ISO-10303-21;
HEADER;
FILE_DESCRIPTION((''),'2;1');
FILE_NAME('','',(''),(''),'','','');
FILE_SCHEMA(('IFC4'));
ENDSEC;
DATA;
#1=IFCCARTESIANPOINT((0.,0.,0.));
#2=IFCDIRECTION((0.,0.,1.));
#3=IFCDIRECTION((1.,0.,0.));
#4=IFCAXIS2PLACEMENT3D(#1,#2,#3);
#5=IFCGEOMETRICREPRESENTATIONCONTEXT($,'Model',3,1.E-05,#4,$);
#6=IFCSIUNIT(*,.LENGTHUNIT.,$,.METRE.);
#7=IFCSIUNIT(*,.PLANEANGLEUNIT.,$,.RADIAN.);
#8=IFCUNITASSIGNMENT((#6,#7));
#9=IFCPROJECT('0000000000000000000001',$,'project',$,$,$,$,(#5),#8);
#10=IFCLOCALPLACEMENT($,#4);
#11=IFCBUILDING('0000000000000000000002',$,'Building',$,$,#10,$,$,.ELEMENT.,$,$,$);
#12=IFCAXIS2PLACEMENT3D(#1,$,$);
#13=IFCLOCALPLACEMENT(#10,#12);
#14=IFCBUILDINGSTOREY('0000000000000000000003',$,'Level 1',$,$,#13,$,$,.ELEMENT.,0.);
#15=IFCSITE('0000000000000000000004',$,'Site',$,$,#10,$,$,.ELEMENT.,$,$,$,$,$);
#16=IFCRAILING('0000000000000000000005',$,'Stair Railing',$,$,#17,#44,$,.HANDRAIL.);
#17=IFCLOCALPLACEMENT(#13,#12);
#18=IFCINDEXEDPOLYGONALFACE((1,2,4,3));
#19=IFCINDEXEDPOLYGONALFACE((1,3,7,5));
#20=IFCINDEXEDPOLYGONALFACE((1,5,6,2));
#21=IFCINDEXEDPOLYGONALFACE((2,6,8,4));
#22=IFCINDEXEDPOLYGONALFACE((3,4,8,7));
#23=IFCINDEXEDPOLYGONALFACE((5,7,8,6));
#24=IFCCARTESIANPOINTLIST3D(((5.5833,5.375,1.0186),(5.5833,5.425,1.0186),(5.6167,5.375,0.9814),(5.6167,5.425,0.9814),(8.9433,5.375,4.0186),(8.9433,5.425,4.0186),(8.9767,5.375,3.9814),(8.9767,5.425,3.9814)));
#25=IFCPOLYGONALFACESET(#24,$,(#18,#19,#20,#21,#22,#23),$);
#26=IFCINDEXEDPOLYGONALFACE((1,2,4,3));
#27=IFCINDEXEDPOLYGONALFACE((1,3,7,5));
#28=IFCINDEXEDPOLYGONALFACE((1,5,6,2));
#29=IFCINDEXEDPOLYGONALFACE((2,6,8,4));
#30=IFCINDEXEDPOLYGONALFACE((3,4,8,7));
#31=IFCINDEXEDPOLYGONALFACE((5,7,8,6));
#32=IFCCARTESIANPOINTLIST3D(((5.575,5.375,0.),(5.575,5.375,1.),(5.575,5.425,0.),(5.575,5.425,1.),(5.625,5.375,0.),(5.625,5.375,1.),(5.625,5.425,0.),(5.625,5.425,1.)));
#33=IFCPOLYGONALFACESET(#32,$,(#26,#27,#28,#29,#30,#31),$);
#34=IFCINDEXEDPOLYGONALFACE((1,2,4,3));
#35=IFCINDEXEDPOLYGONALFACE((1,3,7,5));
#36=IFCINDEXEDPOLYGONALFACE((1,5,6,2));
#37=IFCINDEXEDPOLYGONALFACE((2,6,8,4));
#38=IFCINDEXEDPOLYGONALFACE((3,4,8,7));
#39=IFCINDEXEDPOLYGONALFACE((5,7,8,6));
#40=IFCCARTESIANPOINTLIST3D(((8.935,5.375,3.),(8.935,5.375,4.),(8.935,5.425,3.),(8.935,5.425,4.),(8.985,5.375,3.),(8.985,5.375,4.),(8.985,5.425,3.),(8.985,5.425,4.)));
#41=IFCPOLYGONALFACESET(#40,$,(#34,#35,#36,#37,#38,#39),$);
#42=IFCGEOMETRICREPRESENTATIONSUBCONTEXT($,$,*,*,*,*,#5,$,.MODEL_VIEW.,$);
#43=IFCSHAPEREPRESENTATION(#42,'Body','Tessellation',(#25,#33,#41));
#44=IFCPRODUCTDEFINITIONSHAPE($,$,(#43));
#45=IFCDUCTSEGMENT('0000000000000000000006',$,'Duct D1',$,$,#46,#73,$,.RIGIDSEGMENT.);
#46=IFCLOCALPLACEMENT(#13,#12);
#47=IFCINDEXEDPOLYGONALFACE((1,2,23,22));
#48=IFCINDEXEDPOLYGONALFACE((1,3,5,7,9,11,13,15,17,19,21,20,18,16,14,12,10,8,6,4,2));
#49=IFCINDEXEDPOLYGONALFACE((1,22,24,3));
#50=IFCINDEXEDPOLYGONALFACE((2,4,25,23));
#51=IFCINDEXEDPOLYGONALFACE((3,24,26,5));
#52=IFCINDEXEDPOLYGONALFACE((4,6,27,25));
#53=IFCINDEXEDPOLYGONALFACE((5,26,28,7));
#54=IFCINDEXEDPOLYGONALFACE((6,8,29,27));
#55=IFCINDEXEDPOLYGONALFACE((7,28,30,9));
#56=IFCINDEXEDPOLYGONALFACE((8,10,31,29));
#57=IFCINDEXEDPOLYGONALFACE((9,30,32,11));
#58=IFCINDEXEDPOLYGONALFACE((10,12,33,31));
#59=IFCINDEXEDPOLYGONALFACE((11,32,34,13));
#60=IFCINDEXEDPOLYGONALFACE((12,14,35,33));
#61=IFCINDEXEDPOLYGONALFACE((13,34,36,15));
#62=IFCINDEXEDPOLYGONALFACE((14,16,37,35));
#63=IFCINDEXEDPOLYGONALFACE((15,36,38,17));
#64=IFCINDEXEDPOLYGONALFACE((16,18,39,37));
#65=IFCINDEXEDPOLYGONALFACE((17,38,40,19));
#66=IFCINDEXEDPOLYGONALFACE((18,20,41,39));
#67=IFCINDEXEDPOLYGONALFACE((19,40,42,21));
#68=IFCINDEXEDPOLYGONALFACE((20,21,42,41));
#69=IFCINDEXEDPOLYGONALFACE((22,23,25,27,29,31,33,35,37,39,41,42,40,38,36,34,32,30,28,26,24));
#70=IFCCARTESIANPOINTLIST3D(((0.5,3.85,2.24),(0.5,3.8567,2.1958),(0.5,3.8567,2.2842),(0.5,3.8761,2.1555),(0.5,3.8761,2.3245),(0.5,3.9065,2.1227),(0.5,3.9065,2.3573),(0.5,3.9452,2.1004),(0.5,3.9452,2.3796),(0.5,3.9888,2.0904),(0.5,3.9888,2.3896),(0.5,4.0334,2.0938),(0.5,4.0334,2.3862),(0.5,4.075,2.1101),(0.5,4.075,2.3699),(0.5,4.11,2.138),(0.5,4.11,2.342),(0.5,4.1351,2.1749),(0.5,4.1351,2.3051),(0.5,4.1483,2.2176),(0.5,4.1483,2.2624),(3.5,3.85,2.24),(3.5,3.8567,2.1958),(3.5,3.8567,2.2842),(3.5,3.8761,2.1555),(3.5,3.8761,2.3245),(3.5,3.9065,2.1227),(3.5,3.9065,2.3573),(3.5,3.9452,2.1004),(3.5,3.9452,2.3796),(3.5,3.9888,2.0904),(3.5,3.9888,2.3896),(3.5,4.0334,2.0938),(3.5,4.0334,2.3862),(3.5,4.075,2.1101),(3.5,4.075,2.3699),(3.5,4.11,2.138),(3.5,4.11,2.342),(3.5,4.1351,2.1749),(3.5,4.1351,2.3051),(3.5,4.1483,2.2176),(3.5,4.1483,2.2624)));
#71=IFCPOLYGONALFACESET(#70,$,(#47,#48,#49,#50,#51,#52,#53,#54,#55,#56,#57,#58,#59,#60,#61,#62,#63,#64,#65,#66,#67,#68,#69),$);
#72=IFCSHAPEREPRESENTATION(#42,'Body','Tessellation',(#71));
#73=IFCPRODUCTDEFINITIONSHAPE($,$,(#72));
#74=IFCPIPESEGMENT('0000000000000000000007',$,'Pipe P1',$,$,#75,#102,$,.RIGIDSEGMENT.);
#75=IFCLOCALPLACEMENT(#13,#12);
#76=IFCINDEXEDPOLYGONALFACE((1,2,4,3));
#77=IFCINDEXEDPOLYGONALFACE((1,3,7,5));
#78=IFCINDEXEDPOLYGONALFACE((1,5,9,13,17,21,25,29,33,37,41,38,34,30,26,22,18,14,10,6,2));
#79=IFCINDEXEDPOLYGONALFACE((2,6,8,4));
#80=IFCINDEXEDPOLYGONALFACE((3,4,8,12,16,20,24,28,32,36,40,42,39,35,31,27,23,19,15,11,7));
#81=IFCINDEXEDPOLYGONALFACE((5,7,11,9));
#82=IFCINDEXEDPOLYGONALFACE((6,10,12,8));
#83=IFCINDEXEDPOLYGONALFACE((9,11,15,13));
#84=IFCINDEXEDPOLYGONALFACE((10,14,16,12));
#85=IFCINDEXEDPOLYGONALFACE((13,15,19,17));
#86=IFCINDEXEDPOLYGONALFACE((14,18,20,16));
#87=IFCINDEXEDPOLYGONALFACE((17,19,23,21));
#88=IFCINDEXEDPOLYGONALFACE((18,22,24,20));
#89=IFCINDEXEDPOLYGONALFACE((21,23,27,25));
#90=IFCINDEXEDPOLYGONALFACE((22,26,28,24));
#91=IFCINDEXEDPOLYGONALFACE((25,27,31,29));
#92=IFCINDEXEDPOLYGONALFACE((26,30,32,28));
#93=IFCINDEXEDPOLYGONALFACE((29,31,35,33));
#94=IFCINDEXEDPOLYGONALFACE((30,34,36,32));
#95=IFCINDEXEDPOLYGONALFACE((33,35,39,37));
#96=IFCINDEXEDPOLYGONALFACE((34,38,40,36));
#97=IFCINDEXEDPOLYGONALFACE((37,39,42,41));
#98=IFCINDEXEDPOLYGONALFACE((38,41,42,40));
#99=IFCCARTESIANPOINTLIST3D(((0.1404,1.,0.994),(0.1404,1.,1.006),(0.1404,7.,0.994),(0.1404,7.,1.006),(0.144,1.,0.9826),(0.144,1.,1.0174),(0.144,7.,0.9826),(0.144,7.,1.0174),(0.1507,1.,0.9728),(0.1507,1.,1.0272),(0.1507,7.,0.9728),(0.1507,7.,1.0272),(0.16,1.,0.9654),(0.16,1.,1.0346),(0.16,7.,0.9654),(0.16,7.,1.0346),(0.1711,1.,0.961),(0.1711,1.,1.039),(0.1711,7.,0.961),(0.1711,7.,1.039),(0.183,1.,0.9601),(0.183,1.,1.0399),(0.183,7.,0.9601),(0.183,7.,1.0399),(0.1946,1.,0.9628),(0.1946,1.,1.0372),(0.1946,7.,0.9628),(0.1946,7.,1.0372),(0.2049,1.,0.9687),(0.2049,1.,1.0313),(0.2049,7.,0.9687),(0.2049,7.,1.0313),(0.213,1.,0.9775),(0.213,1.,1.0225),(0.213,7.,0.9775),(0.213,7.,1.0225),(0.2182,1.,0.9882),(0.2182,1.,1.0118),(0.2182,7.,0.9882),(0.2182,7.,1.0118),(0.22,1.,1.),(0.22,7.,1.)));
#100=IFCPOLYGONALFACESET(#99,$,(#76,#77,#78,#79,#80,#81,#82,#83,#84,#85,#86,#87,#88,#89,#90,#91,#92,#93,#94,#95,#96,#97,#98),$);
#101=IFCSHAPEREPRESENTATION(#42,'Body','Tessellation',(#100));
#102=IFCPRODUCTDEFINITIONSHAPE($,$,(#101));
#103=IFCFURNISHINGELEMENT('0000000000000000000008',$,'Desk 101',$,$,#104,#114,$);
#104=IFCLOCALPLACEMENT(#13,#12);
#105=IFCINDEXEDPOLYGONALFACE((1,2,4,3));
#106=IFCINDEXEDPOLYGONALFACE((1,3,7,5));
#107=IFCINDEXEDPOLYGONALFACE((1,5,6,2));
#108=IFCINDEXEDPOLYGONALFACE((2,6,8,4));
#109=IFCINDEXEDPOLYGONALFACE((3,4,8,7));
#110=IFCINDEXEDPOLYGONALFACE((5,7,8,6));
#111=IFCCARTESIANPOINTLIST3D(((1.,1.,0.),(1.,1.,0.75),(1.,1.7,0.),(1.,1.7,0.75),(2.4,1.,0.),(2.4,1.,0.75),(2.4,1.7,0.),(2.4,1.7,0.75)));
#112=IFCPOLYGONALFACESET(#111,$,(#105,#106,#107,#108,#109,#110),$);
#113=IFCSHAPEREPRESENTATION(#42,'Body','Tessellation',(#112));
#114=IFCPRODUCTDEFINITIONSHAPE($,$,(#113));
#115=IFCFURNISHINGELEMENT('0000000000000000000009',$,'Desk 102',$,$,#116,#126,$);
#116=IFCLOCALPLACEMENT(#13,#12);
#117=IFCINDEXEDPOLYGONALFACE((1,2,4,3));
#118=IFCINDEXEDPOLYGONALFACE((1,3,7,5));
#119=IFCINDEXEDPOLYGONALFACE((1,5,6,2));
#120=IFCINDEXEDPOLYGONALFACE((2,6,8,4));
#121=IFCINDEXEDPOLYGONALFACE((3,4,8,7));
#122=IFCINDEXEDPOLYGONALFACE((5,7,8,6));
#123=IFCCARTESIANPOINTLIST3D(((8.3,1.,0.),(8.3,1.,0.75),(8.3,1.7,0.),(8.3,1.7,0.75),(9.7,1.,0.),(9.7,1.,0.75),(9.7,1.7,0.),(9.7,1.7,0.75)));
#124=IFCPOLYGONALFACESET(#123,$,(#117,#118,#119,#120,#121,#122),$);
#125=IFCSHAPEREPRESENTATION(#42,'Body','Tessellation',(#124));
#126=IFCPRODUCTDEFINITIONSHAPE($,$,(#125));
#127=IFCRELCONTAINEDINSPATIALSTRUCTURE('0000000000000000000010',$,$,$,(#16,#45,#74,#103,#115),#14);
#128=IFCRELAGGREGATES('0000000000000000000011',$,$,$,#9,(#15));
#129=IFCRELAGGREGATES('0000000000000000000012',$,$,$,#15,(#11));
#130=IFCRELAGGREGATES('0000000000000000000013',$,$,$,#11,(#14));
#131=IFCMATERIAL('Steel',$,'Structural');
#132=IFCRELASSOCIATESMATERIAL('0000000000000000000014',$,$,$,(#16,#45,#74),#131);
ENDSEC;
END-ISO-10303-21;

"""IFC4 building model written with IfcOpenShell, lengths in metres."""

from ifc_helpers import new_model, si_unit, frame, frame_2d, origin, origin_with_axes, origin_2d, place, context, subcontext, project, spatial, rectangle, circle, extrude, material, element, save


model = new_model("IFC4")

# Units and contexts
model_context = context("Model", 3, precision=1e-05, world=origin_with_axes())
sub_context = subcontext(model_context, None, None, "MODEL_VIEW")
ifc_project = project(units=[si_unit("LENGTHUNIT", "METRE"), si_unit("PLANEANGLEUNIT", "RADIAN")], contexts=[model_context])

# Site, building, storey
placement = place(None, origin_with_axes())
site = spatial("IfcSite", under=ifc_project, at=placement, Name="Site", CompositionType="ELEMENT")
building = spatial("IfcBuilding", under=site, at=placement, Name="Building", CompositionType="ELEMENT")
storey_placement = place(placement, origin())
storey = spatial("IfcBuildingStorey", under=building, at=storey_placement, Name="Level 1", CompositionType="ELEMENT", Elevation=0.0)

# Shared definitions
ifc_material_1 = material(Name="Steel", Category="Structural")

# Railing
railing_placement = place(placement, frame((5.6, 5.4, 0.0)))
element("IfcRailing", 1, at=railing_placement, inside=storey, material=ifc_material_1, Name="Stair Railing", PredefinedType="HANDRAIL", context=sub_context, shape_type="SolidModel", body=[
    extrude(rectangle(XDim=0.05, YDim=0.05, at=origin_2d()), frame((0.0, 0.0, 1.0), z_axis=(0.745938, 0.0, 0.666016), x_axis=(0.0, 1.0, 0.0)), (0.0, 0.0, 1.0), 4.5044),
    extrude(rectangle(XDim=0.05, YDim=0.05, at=origin_2d()), origin(), (0.0, 0.0, 1.0), 1.0),
    extrude(rectangle(XDim=0.05, YDim=0.05, at=origin_2d()), frame((3.36, 0.0, 3.0)), (0.0, 0.0, 1.0), 1.0),
])

# Duct segment
duct_segment_placement = place(placement, frame((0.5, 4.0, 2.24), z_axis=(1.0, 0.0, 0.0), x_axis=(0.0, -1.0, 0.0)))
element("IfcDuctSegment", 2, at=duct_segment_placement, inside=storey, material=ifc_material_1, Name="Duct D1", PredefinedType="RIGIDSEGMENT", context=sub_context, shape_type="SweptSolid", body=[
    extrude(circle(Radius=0.15, at=origin_2d()), origin(), (0.0, 0.0, 1.0), 3.0),
])

# Pipe segment
pipe_segment_placement = place(placement, frame((0.18, 1.0, 1.0), z_axis=(0.0, 1.0, 0.0), x_axis=(1.0, 0.0, 0.0)))
element("IfcPipeSegment", 3, at=pipe_segment_placement, inside=storey, material=ifc_material_1, Name="Pipe P1", PredefinedType="RIGIDSEGMENT", context=sub_context, shape_type="SweptSolid", body=[
    extrude(circle(Radius=0.04, at=origin_2d()), origin(), (0.0, 0.0, 1.0), 6.0),
])

# Furnishing elements
for number, where, name in (
    (4, (1.0, 1.0, 0.0), "Desk 101"),
    (5, (8.3, 1.0, 0.0), "Desk 102"),
):
    element("IfcFurnishingElement", number, at=place(placement, frame(where)), inside=storey, Name=name, context=sub_context, shape_type="SweptSolid", body=[
        extrude(rectangle(XDim=1.4, YDim=0.7, at=frame_2d((0.7, 0.35))), origin(), (0.0, 0.0, 1.0), 0.75),
    ])

save(model, "model.ifc")
